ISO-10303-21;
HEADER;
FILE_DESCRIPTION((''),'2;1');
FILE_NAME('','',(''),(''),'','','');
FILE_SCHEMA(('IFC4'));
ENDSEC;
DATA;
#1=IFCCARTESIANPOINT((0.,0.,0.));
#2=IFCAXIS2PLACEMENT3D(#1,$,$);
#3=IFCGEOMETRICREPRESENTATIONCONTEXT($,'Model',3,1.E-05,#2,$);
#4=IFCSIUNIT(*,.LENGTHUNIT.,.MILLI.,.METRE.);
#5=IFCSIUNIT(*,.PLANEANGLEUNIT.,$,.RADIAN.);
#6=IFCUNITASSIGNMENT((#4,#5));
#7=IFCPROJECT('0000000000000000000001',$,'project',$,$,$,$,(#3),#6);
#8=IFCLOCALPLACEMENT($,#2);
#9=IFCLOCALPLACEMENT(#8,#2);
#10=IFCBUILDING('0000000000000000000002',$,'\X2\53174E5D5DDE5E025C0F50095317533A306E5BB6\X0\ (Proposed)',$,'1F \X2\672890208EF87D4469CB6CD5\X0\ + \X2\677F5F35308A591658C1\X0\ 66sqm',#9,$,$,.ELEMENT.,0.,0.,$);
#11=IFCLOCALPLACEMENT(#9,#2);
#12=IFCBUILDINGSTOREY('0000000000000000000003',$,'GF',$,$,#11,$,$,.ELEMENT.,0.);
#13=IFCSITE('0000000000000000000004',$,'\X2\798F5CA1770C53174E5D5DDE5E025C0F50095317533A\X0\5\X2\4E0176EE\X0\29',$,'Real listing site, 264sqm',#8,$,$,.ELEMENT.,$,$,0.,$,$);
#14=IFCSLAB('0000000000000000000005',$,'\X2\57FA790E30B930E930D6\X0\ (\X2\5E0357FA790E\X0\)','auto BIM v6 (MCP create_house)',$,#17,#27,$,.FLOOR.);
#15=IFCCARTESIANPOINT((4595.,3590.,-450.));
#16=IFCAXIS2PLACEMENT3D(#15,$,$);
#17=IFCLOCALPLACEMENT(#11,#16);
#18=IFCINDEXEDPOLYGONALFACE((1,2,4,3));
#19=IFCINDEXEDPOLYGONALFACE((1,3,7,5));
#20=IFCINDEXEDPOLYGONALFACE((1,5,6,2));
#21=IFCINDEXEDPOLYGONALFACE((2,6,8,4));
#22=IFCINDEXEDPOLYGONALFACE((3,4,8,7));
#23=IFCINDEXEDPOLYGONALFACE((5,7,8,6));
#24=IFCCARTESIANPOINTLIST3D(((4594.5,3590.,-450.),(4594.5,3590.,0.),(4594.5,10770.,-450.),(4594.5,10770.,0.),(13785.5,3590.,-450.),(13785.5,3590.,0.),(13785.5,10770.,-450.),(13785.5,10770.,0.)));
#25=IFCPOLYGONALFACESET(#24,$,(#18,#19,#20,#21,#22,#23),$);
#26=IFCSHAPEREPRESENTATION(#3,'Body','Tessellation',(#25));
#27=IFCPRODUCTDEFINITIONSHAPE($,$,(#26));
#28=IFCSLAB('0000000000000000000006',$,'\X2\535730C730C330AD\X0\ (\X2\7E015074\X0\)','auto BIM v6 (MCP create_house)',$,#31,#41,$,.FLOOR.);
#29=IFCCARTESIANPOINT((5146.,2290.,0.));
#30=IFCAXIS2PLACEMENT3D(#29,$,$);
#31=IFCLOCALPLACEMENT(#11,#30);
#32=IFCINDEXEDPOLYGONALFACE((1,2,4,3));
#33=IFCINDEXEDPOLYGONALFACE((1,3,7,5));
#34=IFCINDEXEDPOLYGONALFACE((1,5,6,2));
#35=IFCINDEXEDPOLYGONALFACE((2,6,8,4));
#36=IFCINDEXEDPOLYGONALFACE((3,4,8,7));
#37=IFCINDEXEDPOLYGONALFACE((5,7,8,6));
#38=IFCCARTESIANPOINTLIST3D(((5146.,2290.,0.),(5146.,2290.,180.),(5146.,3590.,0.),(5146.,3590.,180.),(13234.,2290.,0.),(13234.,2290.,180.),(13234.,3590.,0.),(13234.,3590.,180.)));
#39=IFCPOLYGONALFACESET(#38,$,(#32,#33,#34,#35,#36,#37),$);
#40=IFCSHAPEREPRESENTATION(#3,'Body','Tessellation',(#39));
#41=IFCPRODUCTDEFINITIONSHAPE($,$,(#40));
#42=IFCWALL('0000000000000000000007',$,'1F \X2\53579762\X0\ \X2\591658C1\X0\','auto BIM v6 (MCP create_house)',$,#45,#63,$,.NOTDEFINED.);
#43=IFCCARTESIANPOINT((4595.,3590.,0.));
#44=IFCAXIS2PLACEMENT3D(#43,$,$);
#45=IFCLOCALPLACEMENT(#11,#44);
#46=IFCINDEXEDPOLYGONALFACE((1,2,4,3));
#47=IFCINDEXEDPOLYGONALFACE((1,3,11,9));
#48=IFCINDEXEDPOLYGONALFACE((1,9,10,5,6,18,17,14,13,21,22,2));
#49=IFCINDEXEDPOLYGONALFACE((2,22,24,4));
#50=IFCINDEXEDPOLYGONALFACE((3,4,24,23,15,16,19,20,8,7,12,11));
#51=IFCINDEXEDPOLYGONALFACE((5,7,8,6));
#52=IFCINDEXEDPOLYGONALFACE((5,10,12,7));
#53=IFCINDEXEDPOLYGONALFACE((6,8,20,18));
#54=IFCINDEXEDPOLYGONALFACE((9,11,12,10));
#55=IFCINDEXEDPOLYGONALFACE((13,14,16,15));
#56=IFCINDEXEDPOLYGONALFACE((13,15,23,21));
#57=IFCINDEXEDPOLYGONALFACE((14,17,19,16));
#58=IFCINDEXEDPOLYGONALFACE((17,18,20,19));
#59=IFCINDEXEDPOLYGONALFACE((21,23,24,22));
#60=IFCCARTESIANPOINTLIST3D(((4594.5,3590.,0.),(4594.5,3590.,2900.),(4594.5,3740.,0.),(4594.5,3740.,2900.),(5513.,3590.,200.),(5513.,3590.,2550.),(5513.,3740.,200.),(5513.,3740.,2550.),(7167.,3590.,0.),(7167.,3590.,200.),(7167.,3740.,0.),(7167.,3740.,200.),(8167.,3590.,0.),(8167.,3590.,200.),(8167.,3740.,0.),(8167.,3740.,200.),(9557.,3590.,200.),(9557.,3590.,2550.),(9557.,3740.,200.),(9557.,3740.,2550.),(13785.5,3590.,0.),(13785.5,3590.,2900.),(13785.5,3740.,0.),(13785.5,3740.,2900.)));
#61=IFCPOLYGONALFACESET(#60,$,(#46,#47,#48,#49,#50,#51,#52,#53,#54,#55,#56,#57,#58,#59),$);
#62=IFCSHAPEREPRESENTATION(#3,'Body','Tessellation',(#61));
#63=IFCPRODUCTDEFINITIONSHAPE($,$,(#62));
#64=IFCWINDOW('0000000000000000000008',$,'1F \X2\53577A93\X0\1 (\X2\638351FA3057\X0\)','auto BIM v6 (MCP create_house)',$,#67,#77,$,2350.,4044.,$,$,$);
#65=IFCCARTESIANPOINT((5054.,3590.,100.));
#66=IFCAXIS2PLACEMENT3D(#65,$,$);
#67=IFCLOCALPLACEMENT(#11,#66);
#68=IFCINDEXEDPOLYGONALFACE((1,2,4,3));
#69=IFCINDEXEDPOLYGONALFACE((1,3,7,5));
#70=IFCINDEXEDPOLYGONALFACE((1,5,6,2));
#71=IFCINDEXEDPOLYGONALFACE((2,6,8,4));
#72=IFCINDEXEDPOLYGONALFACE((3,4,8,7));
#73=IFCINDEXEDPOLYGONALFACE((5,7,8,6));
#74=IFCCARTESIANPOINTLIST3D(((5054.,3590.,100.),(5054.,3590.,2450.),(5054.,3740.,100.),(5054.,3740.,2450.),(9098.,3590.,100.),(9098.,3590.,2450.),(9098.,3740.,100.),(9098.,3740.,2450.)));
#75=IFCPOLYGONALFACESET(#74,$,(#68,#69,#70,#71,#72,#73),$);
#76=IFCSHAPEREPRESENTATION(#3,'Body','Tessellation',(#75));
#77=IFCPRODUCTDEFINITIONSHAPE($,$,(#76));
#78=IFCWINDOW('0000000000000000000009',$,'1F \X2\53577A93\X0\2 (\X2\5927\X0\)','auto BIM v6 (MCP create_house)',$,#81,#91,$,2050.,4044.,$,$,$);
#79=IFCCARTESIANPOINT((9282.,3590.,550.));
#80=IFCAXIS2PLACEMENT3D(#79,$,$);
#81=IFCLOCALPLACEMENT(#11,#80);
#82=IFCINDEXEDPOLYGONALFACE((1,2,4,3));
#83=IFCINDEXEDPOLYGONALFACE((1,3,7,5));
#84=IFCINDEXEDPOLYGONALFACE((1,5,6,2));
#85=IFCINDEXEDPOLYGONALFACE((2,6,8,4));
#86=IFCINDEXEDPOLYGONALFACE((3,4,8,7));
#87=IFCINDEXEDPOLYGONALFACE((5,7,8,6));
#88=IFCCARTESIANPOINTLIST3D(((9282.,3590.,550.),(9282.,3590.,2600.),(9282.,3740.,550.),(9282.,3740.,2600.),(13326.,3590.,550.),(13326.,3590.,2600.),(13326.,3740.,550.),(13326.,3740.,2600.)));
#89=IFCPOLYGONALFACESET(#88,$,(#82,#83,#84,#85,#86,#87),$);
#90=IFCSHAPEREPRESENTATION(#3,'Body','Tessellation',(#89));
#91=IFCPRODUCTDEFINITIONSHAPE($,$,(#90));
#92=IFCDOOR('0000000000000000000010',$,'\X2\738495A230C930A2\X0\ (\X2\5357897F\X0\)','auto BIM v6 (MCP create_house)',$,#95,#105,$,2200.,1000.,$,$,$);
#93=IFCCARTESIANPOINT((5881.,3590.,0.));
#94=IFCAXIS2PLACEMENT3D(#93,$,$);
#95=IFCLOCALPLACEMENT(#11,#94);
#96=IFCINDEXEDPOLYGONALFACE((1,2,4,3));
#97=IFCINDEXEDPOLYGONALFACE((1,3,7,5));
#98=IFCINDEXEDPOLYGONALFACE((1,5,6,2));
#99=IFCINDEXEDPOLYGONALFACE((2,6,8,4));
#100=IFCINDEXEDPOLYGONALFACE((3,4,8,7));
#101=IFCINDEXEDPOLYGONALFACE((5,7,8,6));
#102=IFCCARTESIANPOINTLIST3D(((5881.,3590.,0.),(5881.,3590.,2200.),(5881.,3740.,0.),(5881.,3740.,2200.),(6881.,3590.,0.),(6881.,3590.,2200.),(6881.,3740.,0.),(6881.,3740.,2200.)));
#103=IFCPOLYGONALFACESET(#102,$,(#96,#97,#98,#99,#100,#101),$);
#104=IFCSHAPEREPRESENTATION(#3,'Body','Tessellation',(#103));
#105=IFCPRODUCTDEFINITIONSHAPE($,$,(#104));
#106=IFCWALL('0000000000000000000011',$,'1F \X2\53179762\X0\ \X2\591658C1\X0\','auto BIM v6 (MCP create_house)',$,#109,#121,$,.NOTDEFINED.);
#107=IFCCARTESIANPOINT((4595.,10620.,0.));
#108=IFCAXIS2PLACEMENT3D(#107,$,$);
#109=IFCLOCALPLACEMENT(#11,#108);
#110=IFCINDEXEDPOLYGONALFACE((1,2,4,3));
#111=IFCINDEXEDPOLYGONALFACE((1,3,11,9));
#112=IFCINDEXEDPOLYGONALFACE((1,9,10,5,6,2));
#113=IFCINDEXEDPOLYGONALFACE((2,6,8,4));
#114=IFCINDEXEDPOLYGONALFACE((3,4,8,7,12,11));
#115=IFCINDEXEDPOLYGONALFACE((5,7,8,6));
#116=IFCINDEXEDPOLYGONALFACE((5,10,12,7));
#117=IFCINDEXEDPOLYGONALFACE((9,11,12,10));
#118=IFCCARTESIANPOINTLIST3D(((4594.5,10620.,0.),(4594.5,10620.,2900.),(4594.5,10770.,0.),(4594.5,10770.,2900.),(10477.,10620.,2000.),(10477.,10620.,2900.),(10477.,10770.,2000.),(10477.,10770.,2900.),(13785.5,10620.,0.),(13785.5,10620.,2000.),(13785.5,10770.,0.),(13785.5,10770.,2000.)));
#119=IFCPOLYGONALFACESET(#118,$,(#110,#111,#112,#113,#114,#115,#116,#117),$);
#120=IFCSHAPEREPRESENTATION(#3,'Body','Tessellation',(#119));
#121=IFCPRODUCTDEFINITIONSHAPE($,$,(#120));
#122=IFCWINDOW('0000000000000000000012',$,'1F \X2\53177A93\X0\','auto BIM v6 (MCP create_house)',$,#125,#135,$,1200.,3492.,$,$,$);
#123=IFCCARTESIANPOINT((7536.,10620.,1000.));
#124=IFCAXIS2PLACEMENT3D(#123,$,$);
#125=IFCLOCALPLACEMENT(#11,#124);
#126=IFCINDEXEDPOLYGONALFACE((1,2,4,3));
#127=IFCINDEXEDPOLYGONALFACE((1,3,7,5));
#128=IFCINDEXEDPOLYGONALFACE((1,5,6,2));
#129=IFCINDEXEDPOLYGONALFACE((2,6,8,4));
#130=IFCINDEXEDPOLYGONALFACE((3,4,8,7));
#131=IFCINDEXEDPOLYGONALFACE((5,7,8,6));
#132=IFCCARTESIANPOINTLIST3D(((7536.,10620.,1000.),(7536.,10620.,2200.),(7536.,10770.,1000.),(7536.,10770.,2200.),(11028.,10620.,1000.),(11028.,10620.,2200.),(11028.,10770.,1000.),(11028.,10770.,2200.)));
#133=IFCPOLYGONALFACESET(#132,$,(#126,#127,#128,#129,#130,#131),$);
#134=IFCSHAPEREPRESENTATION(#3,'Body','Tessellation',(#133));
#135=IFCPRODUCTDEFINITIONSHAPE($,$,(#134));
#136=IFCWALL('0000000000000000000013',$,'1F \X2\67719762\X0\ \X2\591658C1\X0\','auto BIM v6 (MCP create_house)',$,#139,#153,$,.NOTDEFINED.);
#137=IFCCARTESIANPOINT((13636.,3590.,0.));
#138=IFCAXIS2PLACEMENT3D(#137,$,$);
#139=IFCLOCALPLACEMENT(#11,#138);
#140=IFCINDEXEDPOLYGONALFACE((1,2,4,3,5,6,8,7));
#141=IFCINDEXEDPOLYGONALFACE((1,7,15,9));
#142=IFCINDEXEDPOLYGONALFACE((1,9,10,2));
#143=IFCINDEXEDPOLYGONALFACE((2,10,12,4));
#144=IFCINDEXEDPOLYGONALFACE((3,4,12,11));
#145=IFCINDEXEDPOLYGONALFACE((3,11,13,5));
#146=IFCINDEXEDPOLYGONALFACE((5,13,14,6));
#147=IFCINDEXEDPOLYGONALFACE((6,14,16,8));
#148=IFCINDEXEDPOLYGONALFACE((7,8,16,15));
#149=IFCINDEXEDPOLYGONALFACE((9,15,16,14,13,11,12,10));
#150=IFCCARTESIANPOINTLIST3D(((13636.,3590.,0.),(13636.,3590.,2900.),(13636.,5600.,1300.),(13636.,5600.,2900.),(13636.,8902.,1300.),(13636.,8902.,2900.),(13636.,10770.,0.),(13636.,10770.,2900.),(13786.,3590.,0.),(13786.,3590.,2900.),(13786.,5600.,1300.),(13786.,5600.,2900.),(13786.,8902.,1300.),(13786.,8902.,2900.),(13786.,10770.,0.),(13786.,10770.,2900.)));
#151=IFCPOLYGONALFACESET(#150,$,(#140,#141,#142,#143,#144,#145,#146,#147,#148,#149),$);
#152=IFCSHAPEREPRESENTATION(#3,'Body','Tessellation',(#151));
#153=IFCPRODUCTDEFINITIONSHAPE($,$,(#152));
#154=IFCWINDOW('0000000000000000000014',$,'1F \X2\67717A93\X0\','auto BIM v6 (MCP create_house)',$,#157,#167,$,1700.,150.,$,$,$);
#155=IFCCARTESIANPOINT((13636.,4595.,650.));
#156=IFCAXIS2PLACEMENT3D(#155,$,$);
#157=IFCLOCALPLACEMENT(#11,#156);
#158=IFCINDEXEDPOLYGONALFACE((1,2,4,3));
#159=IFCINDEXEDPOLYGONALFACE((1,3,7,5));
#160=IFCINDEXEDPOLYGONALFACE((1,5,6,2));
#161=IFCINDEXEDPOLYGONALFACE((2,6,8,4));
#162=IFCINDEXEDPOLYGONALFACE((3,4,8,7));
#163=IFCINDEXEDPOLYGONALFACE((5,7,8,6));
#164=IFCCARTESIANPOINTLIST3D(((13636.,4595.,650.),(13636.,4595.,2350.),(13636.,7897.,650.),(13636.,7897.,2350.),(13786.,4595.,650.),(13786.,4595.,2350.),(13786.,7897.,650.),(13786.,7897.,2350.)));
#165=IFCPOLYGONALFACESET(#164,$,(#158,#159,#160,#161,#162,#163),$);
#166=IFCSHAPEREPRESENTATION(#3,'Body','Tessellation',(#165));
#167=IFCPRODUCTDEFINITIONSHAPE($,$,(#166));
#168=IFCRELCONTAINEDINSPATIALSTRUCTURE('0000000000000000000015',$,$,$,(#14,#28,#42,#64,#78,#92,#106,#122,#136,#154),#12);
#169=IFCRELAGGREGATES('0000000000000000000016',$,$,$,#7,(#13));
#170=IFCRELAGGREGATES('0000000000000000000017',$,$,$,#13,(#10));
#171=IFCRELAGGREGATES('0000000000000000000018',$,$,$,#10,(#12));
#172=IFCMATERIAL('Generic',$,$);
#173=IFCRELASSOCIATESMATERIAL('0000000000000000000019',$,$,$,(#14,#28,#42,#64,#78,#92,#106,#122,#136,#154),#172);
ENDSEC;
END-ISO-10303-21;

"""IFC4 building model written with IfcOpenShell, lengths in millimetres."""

from ifc_helpers import new_model, si_unit, frame, frame_2d, origin, place, context, project, spatial, rectangle, extrude, material, element, fill, save


model = new_model("IFC4")

# Units and contexts
model_context = context("Model", 3, precision=1e-05, world=origin())
ifc_project = project(units=[si_unit("LENGTHUNIT", "METRE", prefix="MILLI"), si_unit("PLANEANGLEUNIT", "RADIAN")], contexts=[model_context])

# Site, building, storey
site_placement = place(None, origin())
site = spatial("IfcSite", under=ifc_project, at=site_placement, Name="福岡県北九州市小倉北区5丁目29", ObjectType="Real listing site, 264sqm", CompositionType="ELEMENT", RefElevation=0.0)
building_placement = place(site_placement, origin())
building = spatial("IfcBuilding", under=site, at=building_placement, Name="北九州市小倉北区の家 (Proposed)", ObjectType="1F 木造軸組構法 + 板張り外壁 66sqm", CompositionType="ELEMENT", ElevationOfRefHeight=0.0, ElevationOfTerrain=0.0)
storey_placement = place(building_placement, origin())
storey = spatial("IfcBuildingStorey", under=building, at=storey_placement, Name="GF", CompositionType="ELEMENT", Elevation=0.0)

# Slabs
ifc_material = material(Name="Generic")
slab_1_placement = place(storey_placement, frame((4595.0, 3590.0, -450.0)))
element("IfcSlab", 1, at=slab_1_placement, inside=storey, material=ifc_material, Name="基礎スラブ (布基礎)", Description="auto BIM v6 (MCP create_house)", PredefinedType="FLOOR", context=model_context, shape_type="SweptSolid", body=[
    extrude(rectangle(XDim=9191.0, YDim=7180.0, at=frame_2d((4595.0, 3590.0))), frame((4595.0, 3590.0, -450.0)), (0.0, 0.0, 1.0), 450.0),
])
slab_2_placement = place(storey_placement, frame((5146.0, 2290.0, 0.0)))
element("IfcSlab", 2, at=slab_2_placement, inside=storey, material=ifc_material, Name="南デッキ (縁側)", Description="auto BIM v6 (MCP create_house)", PredefinedType="FLOOR", context=model_context, shape_type="SweptSolid", body=[
    extrude(rectangle(XDim=8088.0, YDim=1300.0, at=frame_2d((4044.0, 650.0))), frame((5146.0, 2290.0, 0.0)), (0.0, 0.0, 1.0), 180.0),
])

# Wall, openings, windows, door
wall_1_placement = place(storey_placement, frame((4595.0, 3590.0, 0.0)))
wall_1 = element("IfcWall", 3, at=wall_1_placement, inside=storey, material=ifc_material, Name="1F 南面 外壁", Description="auto BIM v6 (MCP create_house)", PredefinedType="NOTDEFINED", context=model_context, shape_type="SweptSolid", body=[
    extrude(rectangle(XDim=9191.0, YDim=150.0, at=frame_2d((4595.0, 75.0))), frame((4595.0, 3590.0, 0.0)), (0.0, 0.0, 1.0), 2900.0),
])
opening_1_placement = place(storey_placement, frame((5054.0, 3590.0, 100.0)))
opening_1 = element("IfcOpeningElement", 4, at=opening_1_placement, cuts=wall_1, PredefinedType="NOTDEFINED", context=model_context, shape_type="SweptSolid", body=[
    extrude(rectangle(XDim=4044.0, YDim=150.0, at=frame_2d((2022.0, 75.0))), frame((5054.0, 3590.0, 100.0)), (0.0, 0.0, 1.0), 2350.0),
])
opening_2_placement = place(storey_placement, frame((9282.0, 3590.0, 550.0)))
opening_2 = element("IfcOpeningElement", 5, at=opening_2_placement, cuts=wall_1, PredefinedType="NOTDEFINED", context=model_context, shape_type="SweptSolid", body=[
    extrude(rectangle(XDim=4044.0, YDim=150.0, at=frame_2d((2022.0, 75.0))), frame((9282.0, 3590.0, 550.0)), (0.0, 0.0, 1.0), 2050.0),
])
opening_3_placement = place(storey_placement, frame((5881.0, 3590.0, 0.0)))
opening_3 = element("IfcOpeningElement", 6, at=opening_3_placement, cuts=wall_1, PredefinedType="NOTDEFINED", context=model_context, shape_type="SweptSolid", body=[
    extrude(rectangle(XDim=1000.0, YDim=150.0, at=frame_2d((500.0, 75.0))), frame((5881.0, 3590.0, 0.0)), (0.0, 0.0, 1.0), 2200.0),
])
window_1_placement = place(storey_placement, frame((5054.0, 3590.0, 100.0)))
window_1 = element("IfcWindow", 7, at=window_1_placement, inside=storey, material=ifc_material, Name="1F 南窓1 (掃出し)", Description="auto BIM v6 (MCP create_house)", OverallHeight=2350.0, OverallWidth=4044.0, context=model_context, shape_type="SweptSolid", body=[
    extrude(rectangle(XDim=4044.0, YDim=150.0, at=frame_2d((2022.0, 75.0))), frame((5054.0, 3590.0, 100.0)), (0.0, 0.0, 1.0), 2350.0),
])
fill(opening_1, window_1)
window_2_placement = place(storey_placement, frame((9282.0, 3590.0, 550.0)))
window_2 = element("IfcWindow", 8, at=window_2_placement, inside=storey, material=ifc_material, Name="1F 南窓2 (大)", Description="auto BIM v6 (MCP create_house)", OverallHeight=2050.0, OverallWidth=4044.0, context=model_context, shape_type="SweptSolid", body=[
    extrude(rectangle(XDim=4044.0, YDim=150.0, at=frame_2d((2022.0, 75.0))), frame((9282.0, 3590.0, 550.0)), (0.0, 0.0, 1.0), 2050.0),
])
fill(opening_2, window_2)
door_placement = place(storey_placement, frame((5881.0, 3590.0, 0.0)))
door = element("IfcDoor", 9, at=door_placement, inside=storey, material=ifc_material, Name="玄関ドア (南西)", Description="auto BIM v6 (MCP create_house)", OverallHeight=2200.0, OverallWidth=1000.0, context=model_context, shape_type="SweptSolid", body=[
    extrude(rectangle(XDim=1000.0, YDim=150.0, at=frame_2d((500.0, 75.0))), frame((5881.0, 3590.0, 0.0)), (0.0, 0.0, 1.0), 2200.0),
])
fill(opening_3, door)

# Walls, openings, windows
wall_2_placement = place(storey_placement, frame((4595.0, 10620.0, 0.0)))
wall_2 = element("IfcWall", 10, at=wall_2_placement, inside=storey, material=ifc_material, Name="1F 北面 外壁", Description="auto BIM v6 (MCP create_house)", PredefinedType="NOTDEFINED", context=model_context, shape_type="SweptSolid", body=[
    extrude(rectangle(XDim=9191.0, YDim=150.0, at=frame_2d((4595.0, 75.0))), frame((4595.0, 10620.0, 0.0)), (0.0, 0.0, 1.0), 2900.0),
])
opening_4_placement = place(storey_placement, frame((7536.0, 10620.0, 1000.0)))
opening_4 = element("IfcOpeningElement", 11, at=opening_4_placement, cuts=wall_2, PredefinedType="NOTDEFINED", context=model_context, shape_type="SweptSolid", body=[
    extrude(rectangle(XDim=3492.0, YDim=150.0, at=frame_2d((1746.0, 75.0))), frame((7536.0, 10620.0, 1000.0)), (0.0, 0.0, 1.0), 1200.0),
])
window_3_placement = place(storey_placement, frame((7536.0, 10620.0, 1000.0)))
window_3 = element("IfcWindow", 12, at=window_3_placement, inside=storey, material=ifc_material, Name="1F 北窓", Description="auto BIM v6 (MCP create_house)", OverallHeight=1200.0, OverallWidth=3492.0, context=model_context, shape_type="SweptSolid", body=[
    extrude(rectangle(XDim=3492.0, YDim=150.0, at=frame_2d((1746.0, 75.0))), frame((7536.0, 10620.0, 1000.0)), (0.0, 0.0, 1.0), 1200.0),
])
fill(opening_4, window_3)
wall_3_placement = place(storey_placement, frame((13636.0, 3590.0, 0.0)))
wall_3 = element("IfcWall", 13, at=wall_3_placement, inside=storey, material=ifc_material, Name="1F 東面 外壁", Description="auto BIM v6 (MCP create_house)", PredefinedType="NOTDEFINED", context=model_context, shape_type="SweptSolid", body=[
    extrude(rectangle(XDim=150.0, YDim=7180.0, at=frame_2d((75.0, 3590.0))), frame((13636.0, 3590.0, 0.0)), (0.0, 0.0, 1.0), 2900.0),
])
opening_5_placement = place(storey_placement, frame((13636.0, 4595.0, 650.0)))
opening_5 = element("IfcOpeningElement", 14, at=opening_5_placement, cuts=wall_3, PredefinedType="NOTDEFINED", context=model_context, shape_type="SweptSolid", body=[
    extrude(rectangle(XDim=150.0, YDim=3302.0, at=frame_2d((75.0, 1651.0))), frame((13636.0, 4595.0, 650.0)), (0.0, 0.0, 1.0), 1700.0),
])
window_4_placement = place(storey_placement, frame((13636.0, 4595.0, 650.0)))
window_4 = element("IfcWindow", 15, at=window_4_placement, inside=storey, material=ifc_material, Name="1F 東窓", Description="auto BIM v6 (MCP create_house)", OverallHeight=1700.0, OverallWidth=150.0, context=model_context, shape_type="SweptSolid", body=[
    extrude(rectangle(XDim=150.0, YDim=3302.0, at=frame_2d((75.0, 1651.0))), frame((13636.0, 4595.0, 650.0)), (0.0, 0.0, 1.0), 1700.0),
])
fill(opening_5, window_4)

save(model, "model.ifc")
